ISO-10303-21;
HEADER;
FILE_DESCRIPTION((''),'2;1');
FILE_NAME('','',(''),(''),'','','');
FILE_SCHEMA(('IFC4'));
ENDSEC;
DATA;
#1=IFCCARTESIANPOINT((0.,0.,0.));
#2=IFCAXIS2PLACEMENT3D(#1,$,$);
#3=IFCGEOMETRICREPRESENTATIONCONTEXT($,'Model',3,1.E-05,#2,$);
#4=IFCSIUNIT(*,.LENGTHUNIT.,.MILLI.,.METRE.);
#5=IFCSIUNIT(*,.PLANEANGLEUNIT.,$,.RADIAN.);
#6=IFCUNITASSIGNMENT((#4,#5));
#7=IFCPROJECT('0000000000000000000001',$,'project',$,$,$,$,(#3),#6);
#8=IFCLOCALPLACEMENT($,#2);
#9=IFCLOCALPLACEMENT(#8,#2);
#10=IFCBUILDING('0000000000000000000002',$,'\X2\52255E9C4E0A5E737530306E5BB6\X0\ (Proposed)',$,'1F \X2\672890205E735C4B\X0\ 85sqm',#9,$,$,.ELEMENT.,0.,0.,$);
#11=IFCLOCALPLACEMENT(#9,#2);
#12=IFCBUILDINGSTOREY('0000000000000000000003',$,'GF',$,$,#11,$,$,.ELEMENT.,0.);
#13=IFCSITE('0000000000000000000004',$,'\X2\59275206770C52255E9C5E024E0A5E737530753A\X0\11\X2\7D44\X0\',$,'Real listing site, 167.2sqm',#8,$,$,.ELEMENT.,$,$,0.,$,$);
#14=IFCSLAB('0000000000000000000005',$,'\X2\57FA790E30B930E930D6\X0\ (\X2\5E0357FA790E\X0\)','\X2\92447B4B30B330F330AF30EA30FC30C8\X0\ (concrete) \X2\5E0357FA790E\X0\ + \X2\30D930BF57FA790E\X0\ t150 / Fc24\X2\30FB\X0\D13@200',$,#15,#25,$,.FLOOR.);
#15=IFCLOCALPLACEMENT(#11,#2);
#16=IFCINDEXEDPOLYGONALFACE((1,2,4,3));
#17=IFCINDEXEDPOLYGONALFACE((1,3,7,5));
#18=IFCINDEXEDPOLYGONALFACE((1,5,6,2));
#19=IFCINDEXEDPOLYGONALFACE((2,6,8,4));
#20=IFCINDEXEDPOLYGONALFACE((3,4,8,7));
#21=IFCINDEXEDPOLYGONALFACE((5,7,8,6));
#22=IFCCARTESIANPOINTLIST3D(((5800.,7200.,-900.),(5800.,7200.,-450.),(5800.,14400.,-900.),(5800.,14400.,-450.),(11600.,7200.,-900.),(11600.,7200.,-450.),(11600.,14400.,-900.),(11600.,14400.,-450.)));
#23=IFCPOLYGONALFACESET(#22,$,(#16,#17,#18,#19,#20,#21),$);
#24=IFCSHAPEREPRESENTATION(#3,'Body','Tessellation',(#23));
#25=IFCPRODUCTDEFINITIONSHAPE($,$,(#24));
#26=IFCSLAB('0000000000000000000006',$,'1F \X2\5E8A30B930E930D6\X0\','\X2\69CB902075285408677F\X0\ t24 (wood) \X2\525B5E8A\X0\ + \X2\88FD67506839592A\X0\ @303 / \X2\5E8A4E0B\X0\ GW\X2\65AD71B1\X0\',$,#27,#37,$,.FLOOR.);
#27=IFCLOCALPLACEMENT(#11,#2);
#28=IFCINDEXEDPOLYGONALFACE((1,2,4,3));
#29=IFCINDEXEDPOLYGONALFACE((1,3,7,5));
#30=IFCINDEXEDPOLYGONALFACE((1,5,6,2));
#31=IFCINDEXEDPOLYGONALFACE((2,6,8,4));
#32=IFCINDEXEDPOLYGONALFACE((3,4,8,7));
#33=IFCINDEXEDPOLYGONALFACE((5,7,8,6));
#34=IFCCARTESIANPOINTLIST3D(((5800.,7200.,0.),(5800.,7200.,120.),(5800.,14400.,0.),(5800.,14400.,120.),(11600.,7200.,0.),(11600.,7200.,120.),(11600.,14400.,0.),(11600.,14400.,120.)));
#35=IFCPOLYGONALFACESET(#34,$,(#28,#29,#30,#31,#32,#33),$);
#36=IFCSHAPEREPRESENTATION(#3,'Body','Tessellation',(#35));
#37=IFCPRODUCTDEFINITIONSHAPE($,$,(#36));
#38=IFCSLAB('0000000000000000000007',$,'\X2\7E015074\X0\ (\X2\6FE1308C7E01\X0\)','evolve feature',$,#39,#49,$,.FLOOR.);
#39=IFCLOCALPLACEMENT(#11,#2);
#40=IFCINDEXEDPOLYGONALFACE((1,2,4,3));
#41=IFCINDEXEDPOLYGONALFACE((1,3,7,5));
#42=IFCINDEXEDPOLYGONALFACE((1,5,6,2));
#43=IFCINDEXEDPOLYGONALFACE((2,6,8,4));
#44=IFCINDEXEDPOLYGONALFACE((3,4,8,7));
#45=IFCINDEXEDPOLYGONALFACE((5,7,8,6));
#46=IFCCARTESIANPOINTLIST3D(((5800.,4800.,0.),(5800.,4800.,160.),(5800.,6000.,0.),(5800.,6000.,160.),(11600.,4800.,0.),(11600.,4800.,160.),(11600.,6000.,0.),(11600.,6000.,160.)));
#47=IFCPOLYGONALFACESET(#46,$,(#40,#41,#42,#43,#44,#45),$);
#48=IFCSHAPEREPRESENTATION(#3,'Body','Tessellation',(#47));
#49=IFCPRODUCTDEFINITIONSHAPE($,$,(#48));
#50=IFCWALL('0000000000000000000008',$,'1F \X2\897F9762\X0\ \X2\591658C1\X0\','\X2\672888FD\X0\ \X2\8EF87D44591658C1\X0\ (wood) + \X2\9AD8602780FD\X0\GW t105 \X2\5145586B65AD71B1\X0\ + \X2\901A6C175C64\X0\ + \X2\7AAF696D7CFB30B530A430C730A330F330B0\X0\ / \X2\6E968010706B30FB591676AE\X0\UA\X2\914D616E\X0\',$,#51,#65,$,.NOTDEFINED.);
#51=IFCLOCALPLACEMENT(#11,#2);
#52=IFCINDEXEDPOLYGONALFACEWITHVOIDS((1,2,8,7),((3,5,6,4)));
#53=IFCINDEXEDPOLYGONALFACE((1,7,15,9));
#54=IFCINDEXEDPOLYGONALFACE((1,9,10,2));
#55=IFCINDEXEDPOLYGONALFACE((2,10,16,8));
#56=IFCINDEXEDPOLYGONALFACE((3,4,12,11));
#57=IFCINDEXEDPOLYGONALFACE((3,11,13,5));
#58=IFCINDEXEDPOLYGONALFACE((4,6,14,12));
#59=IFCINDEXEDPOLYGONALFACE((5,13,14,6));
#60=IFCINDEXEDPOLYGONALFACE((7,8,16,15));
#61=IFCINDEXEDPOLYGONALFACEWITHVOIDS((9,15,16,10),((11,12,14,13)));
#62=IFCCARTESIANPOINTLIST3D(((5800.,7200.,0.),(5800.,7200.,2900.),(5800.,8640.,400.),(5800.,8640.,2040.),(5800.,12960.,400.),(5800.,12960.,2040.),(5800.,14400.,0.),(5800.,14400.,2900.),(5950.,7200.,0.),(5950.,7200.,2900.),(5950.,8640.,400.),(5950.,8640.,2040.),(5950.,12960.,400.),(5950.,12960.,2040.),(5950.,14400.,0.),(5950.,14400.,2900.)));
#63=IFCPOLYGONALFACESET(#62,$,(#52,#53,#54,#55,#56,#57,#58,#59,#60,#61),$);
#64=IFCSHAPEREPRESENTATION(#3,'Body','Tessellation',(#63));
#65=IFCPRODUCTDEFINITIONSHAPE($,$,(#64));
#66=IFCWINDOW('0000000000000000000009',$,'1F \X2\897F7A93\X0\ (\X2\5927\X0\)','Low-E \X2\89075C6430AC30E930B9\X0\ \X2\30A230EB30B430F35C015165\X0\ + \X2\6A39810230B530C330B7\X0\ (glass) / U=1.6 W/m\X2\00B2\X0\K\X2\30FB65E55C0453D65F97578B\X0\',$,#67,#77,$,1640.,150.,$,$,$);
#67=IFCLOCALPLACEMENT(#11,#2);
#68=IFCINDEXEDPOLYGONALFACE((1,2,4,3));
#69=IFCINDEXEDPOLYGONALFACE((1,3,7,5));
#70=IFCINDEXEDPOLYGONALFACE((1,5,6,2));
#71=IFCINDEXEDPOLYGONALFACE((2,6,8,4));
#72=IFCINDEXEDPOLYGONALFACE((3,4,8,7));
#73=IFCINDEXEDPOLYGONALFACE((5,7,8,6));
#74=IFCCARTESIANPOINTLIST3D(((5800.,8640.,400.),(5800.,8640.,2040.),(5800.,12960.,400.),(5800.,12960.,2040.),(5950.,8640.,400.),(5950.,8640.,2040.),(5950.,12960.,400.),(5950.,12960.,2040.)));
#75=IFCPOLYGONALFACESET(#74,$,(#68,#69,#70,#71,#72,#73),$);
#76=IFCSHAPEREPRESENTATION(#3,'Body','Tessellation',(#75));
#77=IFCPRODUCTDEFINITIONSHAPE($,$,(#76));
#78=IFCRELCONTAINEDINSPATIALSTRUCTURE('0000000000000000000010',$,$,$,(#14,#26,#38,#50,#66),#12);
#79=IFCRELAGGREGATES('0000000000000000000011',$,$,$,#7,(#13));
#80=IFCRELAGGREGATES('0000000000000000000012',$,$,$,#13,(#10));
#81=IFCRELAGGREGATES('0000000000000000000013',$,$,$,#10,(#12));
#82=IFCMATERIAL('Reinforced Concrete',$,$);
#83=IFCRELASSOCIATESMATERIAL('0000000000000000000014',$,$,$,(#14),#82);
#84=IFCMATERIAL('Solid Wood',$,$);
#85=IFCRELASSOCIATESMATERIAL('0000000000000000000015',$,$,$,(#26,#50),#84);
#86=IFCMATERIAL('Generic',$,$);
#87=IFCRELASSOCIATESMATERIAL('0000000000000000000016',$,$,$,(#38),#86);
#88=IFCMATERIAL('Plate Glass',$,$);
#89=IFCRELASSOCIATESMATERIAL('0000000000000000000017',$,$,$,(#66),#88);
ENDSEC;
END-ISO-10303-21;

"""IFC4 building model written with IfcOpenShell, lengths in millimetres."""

from ifc_helpers import new_model, si_unit, frame, frame_2d, origin, place, context, project, spatial, rectangle, extrude, material, element, fill, save


model = new_model("IFC4")

# Units and contexts
model_context = context("Model", 3, precision=1e-05, world=origin())
ifc_project = project(units=[si_unit("LENGTHUNIT", "METRE", prefix="MILLI"), si_unit("PLANEANGLEUNIT", "RADIAN")], contexts=[model_context])

# Site, building, storey
site_placement = place(None, origin())
site = spatial("IfcSite", under=ifc_project, at=site_placement, Name="大分県別府市上平田町11組", ObjectType="Real listing site, 167.2sqm", CompositionType="ELEMENT", RefElevation=0.0)
building_placement = place(site_placement, origin())
building = spatial("IfcBuilding", under=site, at=building_placement, Name="別府上平田の家 (Proposed)", ObjectType="1F 木造平屋 85sqm", CompositionType="ELEMENT", ElevationOfRefHeight=0.0, ElevationOfTerrain=0.0)
storey_placement = place(building_placement, origin())
storey = spatial("IfcBuildingStorey", under=building, at=storey_placement, Name="GF", CompositionType="ELEMENT", Elevation=0.0)

# Slabs
ifc_material_1 = material(Name="Reinforced Concrete")
slab_1_placement = place(storey_placement, frame((2900.0, 3600.0, -450.0)))
element("IfcSlab", 1, at=slab_1_placement, inside=storey, material=ifc_material_1, Name="基礎スラブ (布基礎)", Description="鉄筋コンクリート (concrete) 布基礎 + ベタ基礎 t150 / Fc24・D13@200", PredefinedType="FLOOR", context=model_context, shape_type="SweptSolid", body=[
    extrude(rectangle(XDim=5800.0, YDim=7200.0, at=frame_2d((2900.0, 3600.0))), frame((2900.0, 3600.0, -450.0)), (0.0, 0.0, 1.0), 450.0),
])
ifc_material_2 = material(Name="Solid Wood")
slab_2_placement = place(storey_placement, frame((2900.0, 3600.0, 0.0)))
element("IfcSlab", 2, at=slab_2_placement, inside=storey, material=ifc_material_2, Name="1F 床スラブ", Description="構造用合板 t24 (wood) 剛床 + 製材根太 @303 / 床下 GW断熱", PredefinedType="FLOOR", context=model_context, shape_type="SweptSolid", body=[
    extrude(rectangle(XDim=5800.0, YDim=7200.0, at=frame_2d((2900.0, 3600.0))), frame((2900.0, 3600.0, 0.0)), (0.0, 0.0, 1.0), 120.0),
])
ifc_material_3 = material(Name="Generic")
slab_3_placement = place(storey_placement, frame((2900.0, 2400.0, 0.0)))
element("IfcSlab", 3, at=slab_3_placement, inside=storey, material=ifc_material_3, Name="縁側 (濡れ縁)", Description="evolve feature", PredefinedType="FLOOR", context=model_context, shape_type="SweptSolid", body=[
    extrude(rectangle(XDim=5800.0, YDim=1200.0, at=frame_2d((2900.0, 600.0))), frame((2900.0, 2400.0, 0.0)), (0.0, 0.0, 1.0), 160.0),
])

# Shared definitions
ifc_material_4 = material(Name="Plate Glass")

# Wall, opening, window
wall_1_placement = place(storey_placement, frame((2900.0, 3600.0, 0.0)))
wall_1 = element("IfcWall", 4, at=wall_1_placement, inside=storey, material=ifc_material_2, Name="1F 西面 外壁", Description="木製 軸組外壁 (wood) + 高性能GW t105 充填断熱 + 通気層 + 窯業系サイディング / 準耐火・外皮UA配慮", PredefinedType="NOTDEFINED", context=model_context, shape_type="SweptSolid", body=[
    extrude(rectangle(XDim=150.0, YDim=7200.0, at=frame_2d((75.0, 3600.0))), frame((2900.0, 3600.0, 0.0)), (0.0, 0.0, 1.0), 2900.0),
])
opening_1_placement = place(storey_placement, frame((2900.0, 4320.0, 200.0)))
opening_1 = element("IfcOpeningElement", 5, at=opening_1_placement, cuts=wall_1, PredefinedType="NOTDEFINED", context=model_context, shape_type="SweptSolid", body=[
    extrude(rectangle(XDim=150.0, YDim=4320.0, at=frame_2d((75.0, 2160.0))), frame((2900.0, 4320.0, 200.0)), (0.0, 0.0, 1.0), 1640.0),
])
window_1_placement = place(storey_placement, frame((2900.0, 4320.0, 200.0)))
window_1 = element("IfcWindow", 6, at=window_1_placement, inside=storey, material=ifc_material_4, Name="1F 西窓 (大)", Description="Low-E 複層ガラス アルゴン封入 + 樹脂サッシ (glass) / U=1.6 W/m²K・日射取得型", OverallHeight=1640.0, OverallWidth=150.0, context=model_context, shape_type="SweptSolid", body=[
    extrude(rectangle(XDim=150.0, YDim=4320.0, at=frame_2d((75.0, 2160.0))), frame((2900.0, 4320.0, 200.0)), (0.0, 0.0, 1.0), 1640.0),
])
fill(opening_1, window_1)

save(model, "model.ifc")
